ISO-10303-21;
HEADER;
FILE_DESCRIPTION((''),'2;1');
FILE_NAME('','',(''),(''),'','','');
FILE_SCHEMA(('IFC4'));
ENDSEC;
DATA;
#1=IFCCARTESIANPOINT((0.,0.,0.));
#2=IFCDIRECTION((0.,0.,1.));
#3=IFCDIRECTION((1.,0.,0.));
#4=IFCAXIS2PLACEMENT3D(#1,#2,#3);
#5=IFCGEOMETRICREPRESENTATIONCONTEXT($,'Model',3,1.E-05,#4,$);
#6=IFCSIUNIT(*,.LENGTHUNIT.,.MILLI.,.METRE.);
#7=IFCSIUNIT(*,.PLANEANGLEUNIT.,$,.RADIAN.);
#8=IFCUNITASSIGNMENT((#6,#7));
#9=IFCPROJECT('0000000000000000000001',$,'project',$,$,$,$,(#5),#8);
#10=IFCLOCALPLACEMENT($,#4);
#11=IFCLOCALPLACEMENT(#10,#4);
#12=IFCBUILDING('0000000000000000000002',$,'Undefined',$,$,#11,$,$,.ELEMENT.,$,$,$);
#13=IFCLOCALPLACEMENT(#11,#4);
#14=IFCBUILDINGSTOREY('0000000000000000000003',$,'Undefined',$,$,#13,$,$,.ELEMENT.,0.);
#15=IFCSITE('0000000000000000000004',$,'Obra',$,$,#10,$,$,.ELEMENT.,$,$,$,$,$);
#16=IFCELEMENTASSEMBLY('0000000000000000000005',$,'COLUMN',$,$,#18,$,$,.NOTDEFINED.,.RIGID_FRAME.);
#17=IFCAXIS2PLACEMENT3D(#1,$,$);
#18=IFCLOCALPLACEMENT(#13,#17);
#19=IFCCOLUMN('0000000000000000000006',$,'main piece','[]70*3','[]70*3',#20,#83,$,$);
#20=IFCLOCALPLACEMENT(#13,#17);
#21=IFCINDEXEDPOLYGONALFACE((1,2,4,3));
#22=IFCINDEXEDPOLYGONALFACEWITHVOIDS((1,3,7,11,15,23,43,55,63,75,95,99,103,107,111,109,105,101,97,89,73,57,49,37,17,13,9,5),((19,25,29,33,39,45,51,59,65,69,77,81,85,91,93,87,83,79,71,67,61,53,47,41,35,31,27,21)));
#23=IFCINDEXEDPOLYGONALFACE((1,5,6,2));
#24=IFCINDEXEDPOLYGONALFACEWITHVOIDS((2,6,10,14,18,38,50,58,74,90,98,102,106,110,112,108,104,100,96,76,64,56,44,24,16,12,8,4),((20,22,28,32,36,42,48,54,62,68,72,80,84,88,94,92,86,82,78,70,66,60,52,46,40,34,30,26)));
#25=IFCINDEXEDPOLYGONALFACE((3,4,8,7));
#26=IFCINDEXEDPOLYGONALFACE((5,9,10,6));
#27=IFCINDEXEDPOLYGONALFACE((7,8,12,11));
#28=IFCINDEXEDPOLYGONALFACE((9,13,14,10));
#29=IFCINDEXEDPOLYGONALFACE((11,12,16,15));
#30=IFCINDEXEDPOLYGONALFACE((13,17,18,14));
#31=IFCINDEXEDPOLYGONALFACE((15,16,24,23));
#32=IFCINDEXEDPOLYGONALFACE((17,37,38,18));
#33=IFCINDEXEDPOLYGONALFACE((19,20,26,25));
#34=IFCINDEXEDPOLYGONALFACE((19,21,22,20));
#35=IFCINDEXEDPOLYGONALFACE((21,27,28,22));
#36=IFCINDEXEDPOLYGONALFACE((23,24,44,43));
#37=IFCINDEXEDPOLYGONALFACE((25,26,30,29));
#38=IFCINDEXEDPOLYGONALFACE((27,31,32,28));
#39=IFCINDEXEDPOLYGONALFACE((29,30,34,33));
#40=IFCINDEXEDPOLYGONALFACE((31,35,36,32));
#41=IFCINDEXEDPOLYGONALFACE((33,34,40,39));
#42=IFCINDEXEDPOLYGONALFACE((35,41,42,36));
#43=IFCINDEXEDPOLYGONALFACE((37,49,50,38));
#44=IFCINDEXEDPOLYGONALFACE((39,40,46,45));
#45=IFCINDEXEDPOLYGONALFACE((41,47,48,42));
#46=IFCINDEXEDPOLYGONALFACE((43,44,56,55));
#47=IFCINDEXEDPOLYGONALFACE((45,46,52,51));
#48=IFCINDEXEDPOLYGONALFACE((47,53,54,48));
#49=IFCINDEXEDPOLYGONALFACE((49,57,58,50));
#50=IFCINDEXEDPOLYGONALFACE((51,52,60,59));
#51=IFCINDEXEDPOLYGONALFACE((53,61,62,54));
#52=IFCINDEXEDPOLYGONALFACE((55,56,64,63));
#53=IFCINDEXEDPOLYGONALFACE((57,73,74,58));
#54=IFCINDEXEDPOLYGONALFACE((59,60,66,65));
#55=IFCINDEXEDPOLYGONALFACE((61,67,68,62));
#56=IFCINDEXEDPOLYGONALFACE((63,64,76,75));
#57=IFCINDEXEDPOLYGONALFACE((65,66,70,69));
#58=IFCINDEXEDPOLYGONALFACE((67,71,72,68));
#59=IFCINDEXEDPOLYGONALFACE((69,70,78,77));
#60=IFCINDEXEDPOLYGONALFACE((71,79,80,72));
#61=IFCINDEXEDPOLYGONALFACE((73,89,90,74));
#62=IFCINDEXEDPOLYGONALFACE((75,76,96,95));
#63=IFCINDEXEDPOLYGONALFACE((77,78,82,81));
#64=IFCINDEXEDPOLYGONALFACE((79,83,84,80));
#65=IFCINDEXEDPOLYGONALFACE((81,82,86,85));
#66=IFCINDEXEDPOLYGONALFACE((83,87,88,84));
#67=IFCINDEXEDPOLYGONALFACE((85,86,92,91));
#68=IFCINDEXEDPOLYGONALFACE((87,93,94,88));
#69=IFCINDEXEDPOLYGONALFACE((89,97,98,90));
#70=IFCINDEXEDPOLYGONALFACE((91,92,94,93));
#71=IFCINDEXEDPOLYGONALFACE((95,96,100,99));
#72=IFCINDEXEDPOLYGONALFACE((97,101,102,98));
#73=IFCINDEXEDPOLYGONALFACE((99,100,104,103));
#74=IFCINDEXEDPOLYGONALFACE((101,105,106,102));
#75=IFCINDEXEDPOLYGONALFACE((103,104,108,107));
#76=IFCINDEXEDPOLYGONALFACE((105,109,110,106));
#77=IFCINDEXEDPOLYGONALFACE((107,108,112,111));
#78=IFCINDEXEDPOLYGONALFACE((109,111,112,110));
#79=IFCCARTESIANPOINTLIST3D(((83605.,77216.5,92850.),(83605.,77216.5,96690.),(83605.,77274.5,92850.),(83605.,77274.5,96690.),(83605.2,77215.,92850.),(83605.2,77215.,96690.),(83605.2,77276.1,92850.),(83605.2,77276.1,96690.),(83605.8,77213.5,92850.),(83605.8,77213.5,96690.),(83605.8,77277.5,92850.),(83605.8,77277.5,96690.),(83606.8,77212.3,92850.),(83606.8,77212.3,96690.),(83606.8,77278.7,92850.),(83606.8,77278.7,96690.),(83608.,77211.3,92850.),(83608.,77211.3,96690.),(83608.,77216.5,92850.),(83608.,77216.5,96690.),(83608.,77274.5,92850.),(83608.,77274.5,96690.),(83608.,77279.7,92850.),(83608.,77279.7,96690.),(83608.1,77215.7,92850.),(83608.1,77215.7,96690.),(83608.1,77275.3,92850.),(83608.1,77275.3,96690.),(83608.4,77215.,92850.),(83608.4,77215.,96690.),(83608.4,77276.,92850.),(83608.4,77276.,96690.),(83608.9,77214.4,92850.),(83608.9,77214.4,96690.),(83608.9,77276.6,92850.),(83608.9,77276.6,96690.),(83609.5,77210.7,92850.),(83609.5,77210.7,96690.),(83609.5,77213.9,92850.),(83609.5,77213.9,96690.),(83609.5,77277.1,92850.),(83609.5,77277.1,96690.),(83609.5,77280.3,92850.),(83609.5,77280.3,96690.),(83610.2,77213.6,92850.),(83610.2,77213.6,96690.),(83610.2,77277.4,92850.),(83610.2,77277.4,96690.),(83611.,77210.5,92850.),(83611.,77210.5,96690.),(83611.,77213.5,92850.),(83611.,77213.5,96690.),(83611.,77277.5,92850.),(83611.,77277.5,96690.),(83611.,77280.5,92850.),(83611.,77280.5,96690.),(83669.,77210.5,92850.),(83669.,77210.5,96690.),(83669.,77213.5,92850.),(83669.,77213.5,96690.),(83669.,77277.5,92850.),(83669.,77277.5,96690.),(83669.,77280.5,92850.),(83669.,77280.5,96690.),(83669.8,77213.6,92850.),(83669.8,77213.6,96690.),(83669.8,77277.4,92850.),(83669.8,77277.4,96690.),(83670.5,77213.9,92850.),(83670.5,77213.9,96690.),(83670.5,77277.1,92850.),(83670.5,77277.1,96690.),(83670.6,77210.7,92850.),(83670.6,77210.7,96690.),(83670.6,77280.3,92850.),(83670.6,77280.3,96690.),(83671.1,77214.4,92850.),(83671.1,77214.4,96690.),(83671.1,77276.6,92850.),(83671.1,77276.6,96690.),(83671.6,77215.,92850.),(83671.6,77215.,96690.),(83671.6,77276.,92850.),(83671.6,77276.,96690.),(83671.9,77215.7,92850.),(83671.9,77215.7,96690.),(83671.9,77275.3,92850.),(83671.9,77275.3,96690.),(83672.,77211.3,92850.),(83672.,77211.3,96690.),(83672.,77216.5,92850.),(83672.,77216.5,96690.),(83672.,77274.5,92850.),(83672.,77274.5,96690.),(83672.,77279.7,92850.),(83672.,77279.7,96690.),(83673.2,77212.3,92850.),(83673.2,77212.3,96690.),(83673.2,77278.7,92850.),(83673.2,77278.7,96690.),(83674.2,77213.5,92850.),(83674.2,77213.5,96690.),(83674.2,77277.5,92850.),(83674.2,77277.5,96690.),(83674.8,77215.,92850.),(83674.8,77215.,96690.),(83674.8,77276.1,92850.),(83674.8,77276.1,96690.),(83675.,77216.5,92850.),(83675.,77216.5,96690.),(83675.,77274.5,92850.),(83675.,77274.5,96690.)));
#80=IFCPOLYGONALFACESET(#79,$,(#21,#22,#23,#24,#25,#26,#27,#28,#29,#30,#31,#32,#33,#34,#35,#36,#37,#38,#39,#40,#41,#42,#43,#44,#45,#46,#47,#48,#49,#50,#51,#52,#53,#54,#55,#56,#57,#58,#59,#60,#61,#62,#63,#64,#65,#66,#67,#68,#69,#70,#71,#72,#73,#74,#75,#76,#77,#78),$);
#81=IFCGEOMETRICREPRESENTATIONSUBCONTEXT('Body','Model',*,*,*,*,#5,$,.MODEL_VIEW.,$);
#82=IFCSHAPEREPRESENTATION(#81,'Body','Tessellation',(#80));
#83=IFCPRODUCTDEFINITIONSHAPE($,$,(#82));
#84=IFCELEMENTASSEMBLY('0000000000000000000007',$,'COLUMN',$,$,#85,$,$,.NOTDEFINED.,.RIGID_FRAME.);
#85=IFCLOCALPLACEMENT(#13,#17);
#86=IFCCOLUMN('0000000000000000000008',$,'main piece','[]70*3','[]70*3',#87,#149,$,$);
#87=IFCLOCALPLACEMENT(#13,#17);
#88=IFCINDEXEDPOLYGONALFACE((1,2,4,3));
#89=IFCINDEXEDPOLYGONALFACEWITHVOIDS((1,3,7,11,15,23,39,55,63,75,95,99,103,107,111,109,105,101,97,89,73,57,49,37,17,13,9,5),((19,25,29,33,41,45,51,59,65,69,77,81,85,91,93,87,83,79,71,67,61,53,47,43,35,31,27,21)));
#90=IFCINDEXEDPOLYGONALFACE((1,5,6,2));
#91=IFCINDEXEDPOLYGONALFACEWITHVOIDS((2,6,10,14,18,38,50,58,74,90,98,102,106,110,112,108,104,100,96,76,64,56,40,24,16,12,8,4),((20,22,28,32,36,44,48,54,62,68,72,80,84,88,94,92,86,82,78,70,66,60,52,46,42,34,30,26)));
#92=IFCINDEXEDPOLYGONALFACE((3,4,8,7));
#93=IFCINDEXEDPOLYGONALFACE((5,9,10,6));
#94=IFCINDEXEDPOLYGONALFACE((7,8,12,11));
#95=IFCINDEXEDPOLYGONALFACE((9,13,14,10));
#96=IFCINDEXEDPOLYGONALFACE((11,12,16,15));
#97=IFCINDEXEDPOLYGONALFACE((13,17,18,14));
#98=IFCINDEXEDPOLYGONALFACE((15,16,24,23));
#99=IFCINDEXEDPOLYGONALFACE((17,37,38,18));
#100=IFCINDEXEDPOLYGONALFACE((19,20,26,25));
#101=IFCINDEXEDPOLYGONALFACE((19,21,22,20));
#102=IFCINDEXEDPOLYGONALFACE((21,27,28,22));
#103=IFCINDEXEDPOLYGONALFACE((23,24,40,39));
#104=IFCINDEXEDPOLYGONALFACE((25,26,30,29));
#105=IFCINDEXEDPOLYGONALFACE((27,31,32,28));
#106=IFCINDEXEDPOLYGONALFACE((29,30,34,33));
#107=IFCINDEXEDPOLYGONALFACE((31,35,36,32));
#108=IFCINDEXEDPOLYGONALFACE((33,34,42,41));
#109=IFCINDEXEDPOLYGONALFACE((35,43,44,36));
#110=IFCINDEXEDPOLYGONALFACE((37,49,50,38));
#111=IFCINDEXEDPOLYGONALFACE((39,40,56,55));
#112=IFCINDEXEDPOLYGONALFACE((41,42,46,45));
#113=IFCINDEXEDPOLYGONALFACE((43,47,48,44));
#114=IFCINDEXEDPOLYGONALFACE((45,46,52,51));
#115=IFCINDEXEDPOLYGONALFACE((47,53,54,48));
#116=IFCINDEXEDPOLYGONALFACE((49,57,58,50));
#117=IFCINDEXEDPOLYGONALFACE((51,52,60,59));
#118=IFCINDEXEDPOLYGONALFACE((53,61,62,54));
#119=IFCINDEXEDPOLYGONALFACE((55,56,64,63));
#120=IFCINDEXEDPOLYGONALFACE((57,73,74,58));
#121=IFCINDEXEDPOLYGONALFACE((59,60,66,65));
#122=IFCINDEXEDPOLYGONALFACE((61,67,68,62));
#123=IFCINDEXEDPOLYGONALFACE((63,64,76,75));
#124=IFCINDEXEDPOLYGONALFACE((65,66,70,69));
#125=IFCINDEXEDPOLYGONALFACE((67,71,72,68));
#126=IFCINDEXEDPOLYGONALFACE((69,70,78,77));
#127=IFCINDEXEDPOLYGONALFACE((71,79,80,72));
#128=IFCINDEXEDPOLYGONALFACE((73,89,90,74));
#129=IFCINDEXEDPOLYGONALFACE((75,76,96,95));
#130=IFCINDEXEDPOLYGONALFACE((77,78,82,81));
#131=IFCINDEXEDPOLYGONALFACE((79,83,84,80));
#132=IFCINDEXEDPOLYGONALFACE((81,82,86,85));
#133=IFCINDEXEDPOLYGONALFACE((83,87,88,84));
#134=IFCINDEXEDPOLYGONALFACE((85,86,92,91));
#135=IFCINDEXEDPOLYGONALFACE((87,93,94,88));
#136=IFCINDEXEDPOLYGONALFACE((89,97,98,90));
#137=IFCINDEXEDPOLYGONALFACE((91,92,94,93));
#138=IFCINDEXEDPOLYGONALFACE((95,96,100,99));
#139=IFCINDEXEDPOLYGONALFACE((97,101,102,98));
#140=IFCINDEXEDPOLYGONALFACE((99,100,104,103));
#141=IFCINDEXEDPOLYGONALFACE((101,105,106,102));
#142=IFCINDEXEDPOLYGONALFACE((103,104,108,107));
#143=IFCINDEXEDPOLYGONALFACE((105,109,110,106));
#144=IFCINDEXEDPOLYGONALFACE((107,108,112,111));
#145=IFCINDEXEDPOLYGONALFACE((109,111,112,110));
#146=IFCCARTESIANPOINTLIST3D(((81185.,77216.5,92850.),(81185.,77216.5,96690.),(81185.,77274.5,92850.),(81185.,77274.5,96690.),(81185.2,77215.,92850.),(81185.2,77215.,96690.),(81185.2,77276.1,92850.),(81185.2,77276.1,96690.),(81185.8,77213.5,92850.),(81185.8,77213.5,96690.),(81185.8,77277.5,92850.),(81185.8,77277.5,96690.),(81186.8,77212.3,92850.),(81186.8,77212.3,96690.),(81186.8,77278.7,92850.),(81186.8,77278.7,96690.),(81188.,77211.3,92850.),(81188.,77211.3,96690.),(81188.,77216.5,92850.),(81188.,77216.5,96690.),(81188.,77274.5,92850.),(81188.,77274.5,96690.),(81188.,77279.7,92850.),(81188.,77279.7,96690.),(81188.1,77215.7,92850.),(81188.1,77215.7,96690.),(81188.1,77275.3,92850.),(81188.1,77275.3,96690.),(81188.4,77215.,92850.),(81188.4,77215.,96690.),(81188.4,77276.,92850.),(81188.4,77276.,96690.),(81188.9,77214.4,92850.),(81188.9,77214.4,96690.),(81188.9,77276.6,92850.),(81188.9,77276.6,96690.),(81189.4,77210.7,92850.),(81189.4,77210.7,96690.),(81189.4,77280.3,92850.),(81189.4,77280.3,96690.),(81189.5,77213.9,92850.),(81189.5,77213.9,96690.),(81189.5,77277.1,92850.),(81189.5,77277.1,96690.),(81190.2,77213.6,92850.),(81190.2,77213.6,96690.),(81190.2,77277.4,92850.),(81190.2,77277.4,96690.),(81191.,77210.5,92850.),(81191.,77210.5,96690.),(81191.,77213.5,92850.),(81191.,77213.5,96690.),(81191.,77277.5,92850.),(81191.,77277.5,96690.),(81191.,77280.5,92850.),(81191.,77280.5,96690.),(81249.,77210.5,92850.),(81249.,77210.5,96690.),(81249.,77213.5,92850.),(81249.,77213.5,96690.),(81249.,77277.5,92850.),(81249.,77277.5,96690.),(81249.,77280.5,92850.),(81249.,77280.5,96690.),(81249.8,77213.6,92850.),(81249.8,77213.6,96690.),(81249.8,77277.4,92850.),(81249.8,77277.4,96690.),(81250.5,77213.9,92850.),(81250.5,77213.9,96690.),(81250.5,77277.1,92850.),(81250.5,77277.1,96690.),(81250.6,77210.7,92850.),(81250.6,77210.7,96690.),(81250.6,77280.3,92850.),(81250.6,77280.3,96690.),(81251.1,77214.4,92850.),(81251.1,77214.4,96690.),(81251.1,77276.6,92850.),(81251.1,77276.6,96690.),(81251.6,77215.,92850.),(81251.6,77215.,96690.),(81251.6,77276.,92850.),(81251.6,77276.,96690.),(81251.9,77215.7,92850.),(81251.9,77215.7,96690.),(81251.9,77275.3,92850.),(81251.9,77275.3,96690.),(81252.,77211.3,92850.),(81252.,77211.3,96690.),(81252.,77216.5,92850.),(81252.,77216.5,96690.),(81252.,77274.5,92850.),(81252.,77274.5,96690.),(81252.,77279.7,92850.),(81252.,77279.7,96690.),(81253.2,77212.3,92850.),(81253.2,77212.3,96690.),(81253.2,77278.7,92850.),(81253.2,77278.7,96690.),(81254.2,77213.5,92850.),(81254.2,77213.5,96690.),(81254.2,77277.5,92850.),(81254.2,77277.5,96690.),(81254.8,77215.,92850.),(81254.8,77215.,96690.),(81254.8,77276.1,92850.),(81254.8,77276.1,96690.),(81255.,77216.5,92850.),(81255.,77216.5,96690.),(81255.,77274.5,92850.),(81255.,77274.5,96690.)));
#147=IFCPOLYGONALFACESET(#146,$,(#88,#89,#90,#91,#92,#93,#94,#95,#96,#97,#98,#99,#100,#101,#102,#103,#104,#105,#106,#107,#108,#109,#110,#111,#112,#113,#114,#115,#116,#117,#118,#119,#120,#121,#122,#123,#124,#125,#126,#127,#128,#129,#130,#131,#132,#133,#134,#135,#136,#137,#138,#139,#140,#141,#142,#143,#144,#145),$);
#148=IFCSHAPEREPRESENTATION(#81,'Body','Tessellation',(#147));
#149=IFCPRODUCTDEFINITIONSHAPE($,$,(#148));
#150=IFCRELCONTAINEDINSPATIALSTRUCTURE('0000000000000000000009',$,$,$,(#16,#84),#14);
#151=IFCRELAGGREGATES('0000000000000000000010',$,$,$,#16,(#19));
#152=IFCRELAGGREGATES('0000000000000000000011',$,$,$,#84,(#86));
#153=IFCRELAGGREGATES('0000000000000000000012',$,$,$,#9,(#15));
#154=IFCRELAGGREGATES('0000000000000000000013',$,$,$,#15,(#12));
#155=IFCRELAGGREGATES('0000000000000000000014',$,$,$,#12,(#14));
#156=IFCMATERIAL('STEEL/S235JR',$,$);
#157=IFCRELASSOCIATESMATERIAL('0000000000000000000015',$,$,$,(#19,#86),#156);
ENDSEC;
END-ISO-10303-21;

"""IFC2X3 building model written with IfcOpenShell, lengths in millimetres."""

from ifc_helpers import new_model, si_unit, frame, origin_with_axes, origin_2d_with_axis, place, context, subcontext, project, spatial, hollow_rectangle, extrude, material, element, aggregate, save


model = new_model("IFC2X3")

# Units and contexts
model_context = context("Model", 3, precision=1e-05, world=origin_with_axes())
body_context = subcontext(model_context, "Body", "Model", "MODEL_VIEW")
ifc_project = project(units=[si_unit("LENGTHUNIT", "METRE", prefix="MILLI"), si_unit("PLANEANGLEUNIT", "RADIAN")], contexts=[model_context])

# Site, building, storey
site_placement = place(None, origin_with_axes())
site = spatial("IfcSite", under=ifc_project, at=site_placement, Name="Obra", CompositionType="ELEMENT")
building_placement = place(site_placement, origin_with_axes())
building = spatial("IfcBuilding", under=site, at=building_placement, Name="Undefined", CompositionType="ELEMENT")
storey_placement = place(building_placement, origin_with_axes())
storey = spatial("IfcBuildingStorey", under=building, at=storey_placement, Name="Undefined", CompositionType="ELEMENT", Elevation=0.0)

# Element assemblies, columns
assembly_1_placement = place(storey_placement, origin_with_axes())
assembly_1 = element("IfcElementAssembly", 1, at=assembly_1_placement, inside=storey, Name="COLUMN", AssemblyPlace="NOTDEFINED", PredefinedType="RIGID_FRAME")
ifc_material = material(Name="STEEL/S235JR")
column_1_placement = place(assembly_1_placement, frame((83640.0, 77245.5, 92850.0), z_axis=(0.0, 0.0, 1.0), x_axis=(0.0, 1.0, 0.0)))
column_1 = element("IfcColumn", 2, at=column_1_placement, material=ifc_material, Name="main piece", Description="[]70*3", ObjectType="[]70*3", context=body_context, shape_type="SweptSolid", body=[
    extrude(hollow_rectangle(XDim=70.0, YDim=70.0, WallThickness=3.0, InnerFilletRadius=3.0, OuterFilletRadius=6.0, at=origin_2d_with_axis()), frame((0.0, 0.0, 3840.0), z_axis=(0.0, 0.0, -1.0), x_axis=(0.0, 1.0, 0.0)), (0.0, 0.0, 1.0), 3840.0),
])
aggregate(assembly_1, [column_1])
assembly_2_placement = place(storey_placement, origin_with_axes())
assembly_2 = element("IfcElementAssembly", 3, at=assembly_2_placement, inside=storey, Name="COLUMN", AssemblyPlace="NOTDEFINED", PredefinedType="RIGID_FRAME")
column_2_placement = place(assembly_2_placement, frame((81220.0, 77245.5, 92850.0), z_axis=(0.0, 0.0, 1.0), x_axis=(0.0, 1.0, 0.0)))
column_2 = element("IfcColumn", 4, at=column_2_placement, material=ifc_material, Name="main piece", Description="[]70*3", ObjectType="[]70*3", context=body_context, shape_type="SweptSolid", body=[
    extrude(hollow_rectangle(XDim=70.0, YDim=70.0, WallThickness=3.0, InnerFilletRadius=3.0, OuterFilletRadius=6.0, at=origin_2d_with_axis()), frame((0.0, 0.0, 3840.0), z_axis=(0.0, 0.0, -1.0), x_axis=(0.0, 1.0, 0.0)), (0.0, 0.0, 1.0), 3840.0),
])
aggregate(assembly_2, [column_2])

save(model, "model.ifc")
